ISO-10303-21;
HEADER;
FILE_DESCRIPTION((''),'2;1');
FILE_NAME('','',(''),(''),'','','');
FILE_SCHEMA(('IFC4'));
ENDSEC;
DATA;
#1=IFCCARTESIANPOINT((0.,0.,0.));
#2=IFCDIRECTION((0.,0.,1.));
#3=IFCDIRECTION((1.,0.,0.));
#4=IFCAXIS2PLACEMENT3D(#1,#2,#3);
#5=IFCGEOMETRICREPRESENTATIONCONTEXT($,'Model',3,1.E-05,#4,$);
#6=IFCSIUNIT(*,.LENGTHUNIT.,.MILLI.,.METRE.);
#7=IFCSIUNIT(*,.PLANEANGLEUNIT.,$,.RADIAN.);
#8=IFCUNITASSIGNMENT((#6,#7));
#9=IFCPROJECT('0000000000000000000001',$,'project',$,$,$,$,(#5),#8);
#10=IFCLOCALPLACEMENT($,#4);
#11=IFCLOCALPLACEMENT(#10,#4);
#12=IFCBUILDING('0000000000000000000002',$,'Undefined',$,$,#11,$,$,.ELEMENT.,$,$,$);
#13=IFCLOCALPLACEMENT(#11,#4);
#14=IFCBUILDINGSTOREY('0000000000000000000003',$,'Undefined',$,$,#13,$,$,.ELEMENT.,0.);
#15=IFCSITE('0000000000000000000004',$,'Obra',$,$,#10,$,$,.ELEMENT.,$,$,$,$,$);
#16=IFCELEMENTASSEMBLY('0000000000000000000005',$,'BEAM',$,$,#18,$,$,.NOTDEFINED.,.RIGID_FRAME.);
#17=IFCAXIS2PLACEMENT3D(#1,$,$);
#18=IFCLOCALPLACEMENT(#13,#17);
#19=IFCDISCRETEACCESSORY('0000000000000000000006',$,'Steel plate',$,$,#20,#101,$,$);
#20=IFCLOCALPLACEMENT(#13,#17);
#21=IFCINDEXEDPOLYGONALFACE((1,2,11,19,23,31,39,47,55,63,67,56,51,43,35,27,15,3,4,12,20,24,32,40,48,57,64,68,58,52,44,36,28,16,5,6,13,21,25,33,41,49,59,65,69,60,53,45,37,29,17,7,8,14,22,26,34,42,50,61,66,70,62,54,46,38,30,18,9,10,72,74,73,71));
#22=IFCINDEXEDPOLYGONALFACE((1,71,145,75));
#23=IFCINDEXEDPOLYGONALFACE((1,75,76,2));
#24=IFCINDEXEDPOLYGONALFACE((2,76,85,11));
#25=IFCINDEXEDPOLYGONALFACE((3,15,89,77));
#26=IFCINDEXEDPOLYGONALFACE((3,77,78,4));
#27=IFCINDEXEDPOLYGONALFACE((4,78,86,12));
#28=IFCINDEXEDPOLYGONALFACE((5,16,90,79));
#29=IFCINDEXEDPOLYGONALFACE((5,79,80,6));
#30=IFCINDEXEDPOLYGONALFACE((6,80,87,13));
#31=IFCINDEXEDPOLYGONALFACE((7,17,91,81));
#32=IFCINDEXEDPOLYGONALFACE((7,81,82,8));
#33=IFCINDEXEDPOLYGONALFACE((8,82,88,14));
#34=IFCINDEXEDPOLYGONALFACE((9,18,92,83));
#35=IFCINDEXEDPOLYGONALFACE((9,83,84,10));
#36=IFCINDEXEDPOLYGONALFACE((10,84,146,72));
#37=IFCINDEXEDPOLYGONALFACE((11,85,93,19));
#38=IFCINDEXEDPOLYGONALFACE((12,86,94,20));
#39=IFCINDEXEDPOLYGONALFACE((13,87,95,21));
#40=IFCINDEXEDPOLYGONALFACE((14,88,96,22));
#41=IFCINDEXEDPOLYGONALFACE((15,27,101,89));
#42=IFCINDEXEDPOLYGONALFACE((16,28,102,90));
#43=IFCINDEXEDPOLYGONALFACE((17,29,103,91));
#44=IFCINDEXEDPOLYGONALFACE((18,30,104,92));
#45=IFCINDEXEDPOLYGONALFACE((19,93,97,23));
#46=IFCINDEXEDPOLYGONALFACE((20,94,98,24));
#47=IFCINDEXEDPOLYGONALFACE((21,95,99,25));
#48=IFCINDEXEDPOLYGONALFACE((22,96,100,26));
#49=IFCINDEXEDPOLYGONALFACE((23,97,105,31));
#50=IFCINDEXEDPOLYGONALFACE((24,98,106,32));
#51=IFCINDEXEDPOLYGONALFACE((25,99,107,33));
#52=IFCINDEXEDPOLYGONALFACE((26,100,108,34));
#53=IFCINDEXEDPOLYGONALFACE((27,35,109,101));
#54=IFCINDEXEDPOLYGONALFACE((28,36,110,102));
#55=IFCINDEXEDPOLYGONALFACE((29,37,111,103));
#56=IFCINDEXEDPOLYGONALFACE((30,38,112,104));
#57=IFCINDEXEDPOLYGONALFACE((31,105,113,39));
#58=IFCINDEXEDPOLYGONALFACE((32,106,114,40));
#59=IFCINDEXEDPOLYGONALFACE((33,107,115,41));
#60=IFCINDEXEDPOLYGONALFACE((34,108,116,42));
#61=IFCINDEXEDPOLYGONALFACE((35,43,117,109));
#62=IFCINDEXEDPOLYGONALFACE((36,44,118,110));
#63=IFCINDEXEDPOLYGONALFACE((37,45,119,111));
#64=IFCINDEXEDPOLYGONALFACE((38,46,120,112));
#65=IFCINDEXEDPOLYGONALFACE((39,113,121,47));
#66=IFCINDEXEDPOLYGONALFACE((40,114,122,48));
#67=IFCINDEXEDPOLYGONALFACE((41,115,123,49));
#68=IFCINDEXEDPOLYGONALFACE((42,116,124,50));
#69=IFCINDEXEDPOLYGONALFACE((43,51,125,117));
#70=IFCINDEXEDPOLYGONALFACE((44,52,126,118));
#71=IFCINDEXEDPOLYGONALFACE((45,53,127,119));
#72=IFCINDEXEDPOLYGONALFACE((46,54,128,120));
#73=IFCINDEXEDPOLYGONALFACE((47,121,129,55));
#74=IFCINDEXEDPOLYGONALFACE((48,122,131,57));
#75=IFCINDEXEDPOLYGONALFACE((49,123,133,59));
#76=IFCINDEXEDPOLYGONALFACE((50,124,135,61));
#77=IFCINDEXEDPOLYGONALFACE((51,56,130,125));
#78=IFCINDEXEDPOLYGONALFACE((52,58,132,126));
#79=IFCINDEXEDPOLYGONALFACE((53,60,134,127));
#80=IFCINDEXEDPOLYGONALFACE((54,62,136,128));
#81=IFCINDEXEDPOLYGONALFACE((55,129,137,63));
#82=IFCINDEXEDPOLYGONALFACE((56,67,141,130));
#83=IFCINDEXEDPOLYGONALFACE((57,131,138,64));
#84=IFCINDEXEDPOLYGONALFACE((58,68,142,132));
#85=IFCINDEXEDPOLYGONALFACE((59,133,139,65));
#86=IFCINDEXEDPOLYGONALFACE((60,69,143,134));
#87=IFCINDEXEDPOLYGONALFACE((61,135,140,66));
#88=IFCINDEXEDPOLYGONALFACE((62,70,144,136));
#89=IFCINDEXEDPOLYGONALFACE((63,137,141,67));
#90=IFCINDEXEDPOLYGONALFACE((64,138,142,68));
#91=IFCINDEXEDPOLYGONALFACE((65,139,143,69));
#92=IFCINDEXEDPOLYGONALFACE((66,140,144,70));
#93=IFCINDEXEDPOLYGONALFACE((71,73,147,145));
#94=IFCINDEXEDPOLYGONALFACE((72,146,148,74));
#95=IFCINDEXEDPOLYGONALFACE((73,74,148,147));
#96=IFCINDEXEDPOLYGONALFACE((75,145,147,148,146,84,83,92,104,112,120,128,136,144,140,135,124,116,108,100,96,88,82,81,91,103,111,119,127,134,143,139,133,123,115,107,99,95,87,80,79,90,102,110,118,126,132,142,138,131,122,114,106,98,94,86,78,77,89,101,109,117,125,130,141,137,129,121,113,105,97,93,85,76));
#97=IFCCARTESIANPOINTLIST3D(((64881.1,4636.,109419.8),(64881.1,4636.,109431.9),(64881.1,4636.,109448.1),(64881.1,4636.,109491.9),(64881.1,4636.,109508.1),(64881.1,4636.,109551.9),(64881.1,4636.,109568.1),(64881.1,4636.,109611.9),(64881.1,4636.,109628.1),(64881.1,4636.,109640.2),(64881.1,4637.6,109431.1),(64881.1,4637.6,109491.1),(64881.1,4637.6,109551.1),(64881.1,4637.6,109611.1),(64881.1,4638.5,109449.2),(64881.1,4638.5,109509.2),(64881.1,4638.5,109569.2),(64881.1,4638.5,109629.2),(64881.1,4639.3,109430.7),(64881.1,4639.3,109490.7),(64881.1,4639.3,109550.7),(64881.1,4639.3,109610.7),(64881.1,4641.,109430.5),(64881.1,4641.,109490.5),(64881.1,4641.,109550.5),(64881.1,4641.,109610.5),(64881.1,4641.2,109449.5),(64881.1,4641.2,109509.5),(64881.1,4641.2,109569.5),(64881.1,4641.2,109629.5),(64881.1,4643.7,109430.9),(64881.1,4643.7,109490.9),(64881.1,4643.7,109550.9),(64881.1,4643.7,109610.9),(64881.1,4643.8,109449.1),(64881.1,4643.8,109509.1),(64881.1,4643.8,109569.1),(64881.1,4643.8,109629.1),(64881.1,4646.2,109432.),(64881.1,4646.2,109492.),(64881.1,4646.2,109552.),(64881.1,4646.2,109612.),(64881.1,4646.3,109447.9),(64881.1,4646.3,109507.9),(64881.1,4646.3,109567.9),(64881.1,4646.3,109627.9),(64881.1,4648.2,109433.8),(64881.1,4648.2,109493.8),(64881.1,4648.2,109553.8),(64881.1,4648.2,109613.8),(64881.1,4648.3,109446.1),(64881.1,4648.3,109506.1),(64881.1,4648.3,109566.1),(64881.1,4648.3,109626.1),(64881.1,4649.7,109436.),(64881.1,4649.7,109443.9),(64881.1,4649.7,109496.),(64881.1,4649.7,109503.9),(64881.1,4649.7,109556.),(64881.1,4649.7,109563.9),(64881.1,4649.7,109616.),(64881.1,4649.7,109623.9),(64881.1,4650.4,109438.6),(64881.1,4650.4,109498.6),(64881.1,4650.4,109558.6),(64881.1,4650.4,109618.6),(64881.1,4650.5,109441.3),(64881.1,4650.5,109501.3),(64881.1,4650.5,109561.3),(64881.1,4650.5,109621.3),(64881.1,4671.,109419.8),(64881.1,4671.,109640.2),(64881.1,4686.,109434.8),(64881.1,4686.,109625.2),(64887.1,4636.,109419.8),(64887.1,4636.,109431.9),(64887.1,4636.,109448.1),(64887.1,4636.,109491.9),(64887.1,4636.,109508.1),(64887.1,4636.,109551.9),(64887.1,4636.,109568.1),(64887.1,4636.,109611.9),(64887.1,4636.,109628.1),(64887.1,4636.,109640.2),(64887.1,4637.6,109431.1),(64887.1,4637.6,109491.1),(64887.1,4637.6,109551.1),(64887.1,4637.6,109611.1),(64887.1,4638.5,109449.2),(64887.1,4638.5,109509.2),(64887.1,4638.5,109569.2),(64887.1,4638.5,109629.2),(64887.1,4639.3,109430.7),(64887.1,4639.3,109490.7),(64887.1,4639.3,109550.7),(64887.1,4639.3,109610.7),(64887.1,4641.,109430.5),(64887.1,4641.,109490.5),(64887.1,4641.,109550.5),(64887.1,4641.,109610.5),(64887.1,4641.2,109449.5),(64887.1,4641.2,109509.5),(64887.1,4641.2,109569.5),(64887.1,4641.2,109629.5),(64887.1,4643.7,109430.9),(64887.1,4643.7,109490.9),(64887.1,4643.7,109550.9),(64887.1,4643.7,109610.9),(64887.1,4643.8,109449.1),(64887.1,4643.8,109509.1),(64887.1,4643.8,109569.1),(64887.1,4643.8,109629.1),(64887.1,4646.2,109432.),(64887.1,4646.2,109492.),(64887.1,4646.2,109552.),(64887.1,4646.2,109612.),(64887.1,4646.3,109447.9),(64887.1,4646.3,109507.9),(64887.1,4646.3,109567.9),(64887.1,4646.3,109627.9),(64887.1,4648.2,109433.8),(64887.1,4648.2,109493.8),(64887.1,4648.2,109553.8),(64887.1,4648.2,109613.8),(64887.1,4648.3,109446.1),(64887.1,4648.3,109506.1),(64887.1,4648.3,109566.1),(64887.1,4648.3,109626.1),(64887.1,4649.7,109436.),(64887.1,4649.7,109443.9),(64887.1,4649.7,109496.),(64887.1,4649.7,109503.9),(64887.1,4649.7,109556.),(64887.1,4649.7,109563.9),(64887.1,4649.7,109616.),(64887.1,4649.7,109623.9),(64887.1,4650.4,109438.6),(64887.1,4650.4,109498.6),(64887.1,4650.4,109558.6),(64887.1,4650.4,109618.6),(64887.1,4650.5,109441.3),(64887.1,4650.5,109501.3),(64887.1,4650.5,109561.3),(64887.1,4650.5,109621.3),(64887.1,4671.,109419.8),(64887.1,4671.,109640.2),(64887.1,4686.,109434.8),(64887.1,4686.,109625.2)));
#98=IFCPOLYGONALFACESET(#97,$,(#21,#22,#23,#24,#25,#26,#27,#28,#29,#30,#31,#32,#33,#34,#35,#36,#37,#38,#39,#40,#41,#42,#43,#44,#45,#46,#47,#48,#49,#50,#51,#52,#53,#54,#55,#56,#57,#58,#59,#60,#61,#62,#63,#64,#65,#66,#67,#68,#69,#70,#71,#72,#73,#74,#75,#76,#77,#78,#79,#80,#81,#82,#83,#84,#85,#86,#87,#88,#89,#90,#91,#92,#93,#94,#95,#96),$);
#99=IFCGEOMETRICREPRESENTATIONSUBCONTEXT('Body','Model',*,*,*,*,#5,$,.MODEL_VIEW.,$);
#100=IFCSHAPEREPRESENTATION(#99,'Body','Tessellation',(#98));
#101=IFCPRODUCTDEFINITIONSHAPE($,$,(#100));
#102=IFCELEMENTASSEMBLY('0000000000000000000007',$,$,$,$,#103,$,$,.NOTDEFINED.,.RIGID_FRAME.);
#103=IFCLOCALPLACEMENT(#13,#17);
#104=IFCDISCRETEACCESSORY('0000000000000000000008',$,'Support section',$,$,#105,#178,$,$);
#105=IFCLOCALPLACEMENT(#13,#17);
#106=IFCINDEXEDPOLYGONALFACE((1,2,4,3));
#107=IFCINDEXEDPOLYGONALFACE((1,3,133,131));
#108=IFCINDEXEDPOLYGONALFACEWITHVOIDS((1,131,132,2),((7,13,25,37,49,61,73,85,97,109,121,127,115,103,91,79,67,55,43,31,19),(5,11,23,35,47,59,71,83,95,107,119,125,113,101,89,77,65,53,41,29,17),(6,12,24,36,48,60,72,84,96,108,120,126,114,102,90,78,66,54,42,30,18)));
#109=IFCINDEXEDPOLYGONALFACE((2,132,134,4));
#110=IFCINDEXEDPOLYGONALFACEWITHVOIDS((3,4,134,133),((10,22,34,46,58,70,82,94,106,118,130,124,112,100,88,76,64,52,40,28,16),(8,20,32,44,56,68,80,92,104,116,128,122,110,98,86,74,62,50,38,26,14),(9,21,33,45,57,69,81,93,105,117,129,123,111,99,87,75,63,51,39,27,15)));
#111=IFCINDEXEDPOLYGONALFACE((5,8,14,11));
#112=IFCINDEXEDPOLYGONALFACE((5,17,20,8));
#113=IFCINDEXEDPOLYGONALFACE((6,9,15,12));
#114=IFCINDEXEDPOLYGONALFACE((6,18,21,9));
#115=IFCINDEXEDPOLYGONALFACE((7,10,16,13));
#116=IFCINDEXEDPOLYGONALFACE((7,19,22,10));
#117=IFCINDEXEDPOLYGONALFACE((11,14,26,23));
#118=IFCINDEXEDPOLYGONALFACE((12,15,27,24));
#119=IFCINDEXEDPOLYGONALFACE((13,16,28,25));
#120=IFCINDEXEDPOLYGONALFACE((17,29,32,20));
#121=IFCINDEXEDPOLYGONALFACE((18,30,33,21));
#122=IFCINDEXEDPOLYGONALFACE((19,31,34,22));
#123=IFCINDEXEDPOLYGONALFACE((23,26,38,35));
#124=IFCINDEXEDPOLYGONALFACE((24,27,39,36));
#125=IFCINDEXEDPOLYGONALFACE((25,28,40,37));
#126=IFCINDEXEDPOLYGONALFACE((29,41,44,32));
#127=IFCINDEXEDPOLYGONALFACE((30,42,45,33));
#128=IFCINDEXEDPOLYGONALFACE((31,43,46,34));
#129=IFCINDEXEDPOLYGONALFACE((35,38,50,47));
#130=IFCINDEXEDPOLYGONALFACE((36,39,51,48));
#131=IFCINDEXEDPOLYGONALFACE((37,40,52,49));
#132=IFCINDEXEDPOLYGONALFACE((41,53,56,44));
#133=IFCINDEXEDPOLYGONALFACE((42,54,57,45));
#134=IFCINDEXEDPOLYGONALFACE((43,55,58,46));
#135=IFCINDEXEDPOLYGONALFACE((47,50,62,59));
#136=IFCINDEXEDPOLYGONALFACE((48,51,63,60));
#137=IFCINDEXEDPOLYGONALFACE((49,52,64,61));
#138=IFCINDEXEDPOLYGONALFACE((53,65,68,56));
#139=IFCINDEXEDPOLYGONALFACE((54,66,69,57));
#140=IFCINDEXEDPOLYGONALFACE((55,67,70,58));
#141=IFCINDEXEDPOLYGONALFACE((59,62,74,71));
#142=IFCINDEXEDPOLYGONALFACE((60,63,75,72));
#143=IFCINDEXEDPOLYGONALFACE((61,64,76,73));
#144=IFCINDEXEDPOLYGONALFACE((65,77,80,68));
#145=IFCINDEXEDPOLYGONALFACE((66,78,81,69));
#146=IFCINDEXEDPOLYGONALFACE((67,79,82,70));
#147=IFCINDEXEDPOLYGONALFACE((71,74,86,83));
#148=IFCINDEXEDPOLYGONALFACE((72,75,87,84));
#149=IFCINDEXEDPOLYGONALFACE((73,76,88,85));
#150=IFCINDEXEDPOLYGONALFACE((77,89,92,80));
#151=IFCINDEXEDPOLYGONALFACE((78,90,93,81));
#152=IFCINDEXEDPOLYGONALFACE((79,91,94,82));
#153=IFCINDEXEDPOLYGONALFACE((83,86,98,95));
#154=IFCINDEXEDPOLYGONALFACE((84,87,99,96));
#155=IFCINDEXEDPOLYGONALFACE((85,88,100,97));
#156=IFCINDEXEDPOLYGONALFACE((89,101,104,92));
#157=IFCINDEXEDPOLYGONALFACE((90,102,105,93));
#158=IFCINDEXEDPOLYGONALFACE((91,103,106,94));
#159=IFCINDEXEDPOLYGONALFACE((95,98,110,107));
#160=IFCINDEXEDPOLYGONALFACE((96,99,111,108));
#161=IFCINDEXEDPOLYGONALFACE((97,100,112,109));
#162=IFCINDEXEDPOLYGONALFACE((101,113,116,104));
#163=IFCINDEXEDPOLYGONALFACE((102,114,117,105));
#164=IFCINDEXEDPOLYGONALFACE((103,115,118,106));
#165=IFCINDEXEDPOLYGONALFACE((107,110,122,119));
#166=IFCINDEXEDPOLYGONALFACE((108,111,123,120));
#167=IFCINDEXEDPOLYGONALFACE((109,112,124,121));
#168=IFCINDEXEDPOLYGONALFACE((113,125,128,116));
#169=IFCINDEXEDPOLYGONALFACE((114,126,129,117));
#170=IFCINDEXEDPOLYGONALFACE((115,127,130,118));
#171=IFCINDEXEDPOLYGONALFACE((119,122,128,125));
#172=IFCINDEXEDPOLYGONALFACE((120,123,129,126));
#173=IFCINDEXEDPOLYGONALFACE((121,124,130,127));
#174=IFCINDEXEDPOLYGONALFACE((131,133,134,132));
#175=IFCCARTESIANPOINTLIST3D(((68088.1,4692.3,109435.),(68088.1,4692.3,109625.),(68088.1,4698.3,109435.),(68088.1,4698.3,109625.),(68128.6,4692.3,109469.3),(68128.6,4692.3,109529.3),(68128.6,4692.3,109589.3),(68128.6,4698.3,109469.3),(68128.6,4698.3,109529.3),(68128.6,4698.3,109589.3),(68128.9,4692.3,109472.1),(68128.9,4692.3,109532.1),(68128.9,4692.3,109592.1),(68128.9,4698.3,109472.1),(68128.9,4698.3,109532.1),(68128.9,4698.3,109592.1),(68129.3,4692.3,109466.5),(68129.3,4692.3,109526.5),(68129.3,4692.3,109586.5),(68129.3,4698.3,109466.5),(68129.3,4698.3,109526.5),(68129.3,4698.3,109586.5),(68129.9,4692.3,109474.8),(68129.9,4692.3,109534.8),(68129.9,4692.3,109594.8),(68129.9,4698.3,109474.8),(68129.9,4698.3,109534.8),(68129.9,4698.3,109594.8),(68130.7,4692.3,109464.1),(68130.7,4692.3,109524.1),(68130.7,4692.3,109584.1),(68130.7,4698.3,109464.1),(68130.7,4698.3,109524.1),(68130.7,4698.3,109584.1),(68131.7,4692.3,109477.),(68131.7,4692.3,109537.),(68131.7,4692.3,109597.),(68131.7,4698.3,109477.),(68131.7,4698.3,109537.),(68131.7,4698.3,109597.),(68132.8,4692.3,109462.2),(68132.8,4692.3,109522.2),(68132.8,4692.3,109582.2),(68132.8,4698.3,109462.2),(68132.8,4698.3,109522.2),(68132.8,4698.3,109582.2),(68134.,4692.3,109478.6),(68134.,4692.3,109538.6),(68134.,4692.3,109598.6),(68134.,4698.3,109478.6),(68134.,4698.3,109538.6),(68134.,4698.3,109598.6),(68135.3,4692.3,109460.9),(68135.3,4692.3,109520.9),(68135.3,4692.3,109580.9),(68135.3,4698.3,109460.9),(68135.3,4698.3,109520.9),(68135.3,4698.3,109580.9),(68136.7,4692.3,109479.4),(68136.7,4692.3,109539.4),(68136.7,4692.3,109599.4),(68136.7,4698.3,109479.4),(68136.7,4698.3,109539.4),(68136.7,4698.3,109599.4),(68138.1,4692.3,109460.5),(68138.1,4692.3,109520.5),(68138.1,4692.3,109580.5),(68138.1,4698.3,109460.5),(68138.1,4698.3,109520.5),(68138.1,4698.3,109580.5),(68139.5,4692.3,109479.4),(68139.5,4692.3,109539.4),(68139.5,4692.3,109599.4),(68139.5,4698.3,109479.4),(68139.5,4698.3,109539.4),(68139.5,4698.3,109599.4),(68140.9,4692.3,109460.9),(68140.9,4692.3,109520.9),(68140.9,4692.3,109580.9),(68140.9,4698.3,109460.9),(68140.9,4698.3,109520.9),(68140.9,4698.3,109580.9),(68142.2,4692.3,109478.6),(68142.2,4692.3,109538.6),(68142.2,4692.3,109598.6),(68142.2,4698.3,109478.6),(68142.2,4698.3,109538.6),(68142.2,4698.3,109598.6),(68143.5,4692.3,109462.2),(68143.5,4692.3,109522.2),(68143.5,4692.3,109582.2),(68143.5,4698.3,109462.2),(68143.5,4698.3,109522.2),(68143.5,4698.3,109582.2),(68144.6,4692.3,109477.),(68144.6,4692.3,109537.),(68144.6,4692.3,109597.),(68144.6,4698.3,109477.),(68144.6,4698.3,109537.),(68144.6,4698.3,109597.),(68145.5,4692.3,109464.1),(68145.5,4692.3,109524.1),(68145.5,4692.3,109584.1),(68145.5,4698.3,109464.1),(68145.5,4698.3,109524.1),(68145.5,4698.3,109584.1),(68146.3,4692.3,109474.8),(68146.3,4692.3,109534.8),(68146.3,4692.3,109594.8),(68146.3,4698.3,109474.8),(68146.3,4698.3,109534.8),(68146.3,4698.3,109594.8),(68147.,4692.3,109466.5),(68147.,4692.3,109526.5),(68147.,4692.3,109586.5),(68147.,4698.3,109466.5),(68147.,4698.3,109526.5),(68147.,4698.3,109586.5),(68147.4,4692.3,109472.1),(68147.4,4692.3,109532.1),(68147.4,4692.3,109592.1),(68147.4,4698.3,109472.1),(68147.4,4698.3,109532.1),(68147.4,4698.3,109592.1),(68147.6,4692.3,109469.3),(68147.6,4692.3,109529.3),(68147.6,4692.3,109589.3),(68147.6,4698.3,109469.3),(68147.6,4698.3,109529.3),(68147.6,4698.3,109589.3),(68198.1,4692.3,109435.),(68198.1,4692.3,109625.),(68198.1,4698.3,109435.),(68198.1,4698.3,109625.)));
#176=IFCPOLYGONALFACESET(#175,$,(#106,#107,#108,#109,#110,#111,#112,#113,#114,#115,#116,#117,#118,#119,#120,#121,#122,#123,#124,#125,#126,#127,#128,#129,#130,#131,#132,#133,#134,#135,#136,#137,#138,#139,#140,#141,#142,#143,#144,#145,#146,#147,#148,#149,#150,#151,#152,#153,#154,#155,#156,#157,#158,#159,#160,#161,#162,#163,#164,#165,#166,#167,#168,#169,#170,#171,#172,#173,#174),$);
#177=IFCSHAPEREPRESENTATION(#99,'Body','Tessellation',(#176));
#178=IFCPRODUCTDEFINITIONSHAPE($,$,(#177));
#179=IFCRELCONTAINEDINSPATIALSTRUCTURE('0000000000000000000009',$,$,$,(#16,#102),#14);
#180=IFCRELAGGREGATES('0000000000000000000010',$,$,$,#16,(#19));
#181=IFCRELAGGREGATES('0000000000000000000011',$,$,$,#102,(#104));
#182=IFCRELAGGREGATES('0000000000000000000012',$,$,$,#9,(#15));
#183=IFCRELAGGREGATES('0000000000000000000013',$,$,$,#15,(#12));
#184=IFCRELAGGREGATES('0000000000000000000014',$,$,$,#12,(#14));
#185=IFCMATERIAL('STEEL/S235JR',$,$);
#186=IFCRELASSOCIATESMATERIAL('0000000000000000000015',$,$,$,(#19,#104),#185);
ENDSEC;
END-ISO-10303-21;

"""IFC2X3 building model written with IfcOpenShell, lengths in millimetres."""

from ifc_helpers import new_model, si_unit, frame, origin_with_axes, origin_2d_with_axis, place, context, subcontext, project, spatial, polyline, rectangle, circle, outline, extrude, source, transform, mapped, material, element, aggregate, save


model = new_model("IFC2X3")

# Units and contexts
model_context = context("Model", 3, precision=1e-05, world=origin_with_axes())
body_context = subcontext(model_context, "Body", "Model", "MODEL_VIEW")
ifc_project = project(units=[si_unit("LENGTHUNIT", "METRE", prefix="MILLI"), si_unit("PLANEANGLEUNIT", "RADIAN")], contexts=[model_context])

# Site, building, storey
site_placement = place(None, origin_with_axes())
site = spatial("IfcSite", under=ifc_project, at=site_placement, Name="Obra", CompositionType="ELEMENT")
building_placement = place(site_placement, origin_with_axes())
building = spatial("IfcBuilding", under=site, at=building_placement, Name="Undefined", CompositionType="ELEMENT")
storey_placement = place(building_placement, origin_with_axes())
storey = spatial("IfcBuildingStorey", under=building, at=storey_placement, Name="Undefined", CompositionType="ELEMENT", Elevation=0.0)

# Shared definitions
ifc_material_1 = material(Name="STEEL/S235JR")

# Shared definitions
shared_shape_1 = source(origin_with_axes(), body_context, "Body", "SweptSolid", [
    extrude(circle(Radius=9.5, at=origin_2d_with_axis()), frame((0.0, -9.2, 0.0), z_axis=(0.0, 1.0, 0.0), x_axis=(1.0, 0.0, 0.0)), (0.0, 0.0, 1.0), 6.2),
])

# Element assembly
assembly_1_placement = place(storey_placement, origin_with_axes())
assembly_1 = element("IfcElementAssembly", 1, at=assembly_1_placement, inside=storey, Name="BEAM", AssemblyPlace="NOTDEFINED", PredefinedType="RIGID_FRAME")

# Discrete accessory, opening
discrete_accessory_1_placement = place(assembly_1_placement, frame((64884.1, 4636.0, 109419.8), z_axis=(1.0, 0.0, 0.0), x_axis=(0.0, 1.0, 0.0)))
discrete_accessory_1 = element("IfcDiscreteAccessory", 2, at=discrete_accessory_1_placement, material=ifc_material_1, Name="Steel plate", context=body_context, shape_type="SweptSolid", body=[
    extrude(outline(polyline([(0.0, 0.0), (35.0, 0.0), (50.0, 15.0), (50.0, 205.4), (35.0, 220.4), (0.0, 220.4), (0.0, 0.0)])), frame((0.0, 0.0, -3.0), z_axis=(0.0, 0.0, 1.0), x_axis=(1.0, 0.0, 0.0)), (0.0, 0.0, 1.0), 6.0),
])
opening_1_placement = place(assembly_1_placement, frame((64890.2, 4676.0, 109650.0), z_axis=(0.0, -1.0, 0.0), x_axis=(0.0, 0.0, -1.0)))
element("IfcOpeningElement", 3, at=opening_1_placement, cuts=discrete_accessory_1, ObjectType="Opening", context=body_context, shape_type="MappedRepresentation", body=[
    mapped(shared_shape_1, transform((30.0, 0.0, 35.0))),
    mapped(shared_shape_1, transform((90.0, 0.0, 35.0))),
    mapped(shared_shape_1, transform((150.0, 0.0, 35.0))),
    mapped(shared_shape_1, transform((210.0, 0.0, 35.0))),
])
aggregate(assembly_1, [discrete_accessory_1])

# Element assembly, discrete accessory, opening
assembly_2_placement = place(storey_placement, origin_with_axes())
assembly_2 = element("IfcElementAssembly", 4, at=assembly_2_placement, inside=storey, AssemblyPlace="NOTDEFINED", PredefinedType="RIGID_FRAME")
discrete_accessory_2_placement = place(assembly_2_placement, frame((68143.1, 4695.3, 109435.0), z_axis=(0.0, 0.0, 1.0), x_axis=(1.0, -0.000126, 0.0)))
discrete_accessory_2 = element("IfcDiscreteAccessory", 5, at=discrete_accessory_2_placement, material=ifc_material_1, Name="Support section", context=body_context, shape_type="SweptSolid", body=[
    extrude(rectangle(XDim=6.0, YDim=110.0, at=origin_2d_with_axis()), frame((0.0, 0.0, 190.0), z_axis=(0.0, 0.0, -1.0), x_axis=(0.0, 1.0, 0.0)), (0.0, 0.0, 1.0), 190.0),
])
opening_2_placement = place(assembly_2_placement, frame((68188.1, 4689.2, 109650.0), z_axis=(-1.0, 0.000126, 0.0), x_axis=(0.0, 0.0, -1.0)))
element("IfcOpeningElement", 6, at=opening_2_placement, cuts=discrete_accessory_2, ObjectType="Opening", context=body_context, shape_type="MappedRepresentation", body=[
    mapped(shared_shape_1, transform((60.0, 0.0, 50.0))),
    mapped(shared_shape_1, transform((120.0, 0.0, 50.0))),
    mapped(shared_shape_1, transform((180.0, 0.0, 50.0))),
])
aggregate(assembly_2, [discrete_accessory_2])

save(model, "model.ifc")
